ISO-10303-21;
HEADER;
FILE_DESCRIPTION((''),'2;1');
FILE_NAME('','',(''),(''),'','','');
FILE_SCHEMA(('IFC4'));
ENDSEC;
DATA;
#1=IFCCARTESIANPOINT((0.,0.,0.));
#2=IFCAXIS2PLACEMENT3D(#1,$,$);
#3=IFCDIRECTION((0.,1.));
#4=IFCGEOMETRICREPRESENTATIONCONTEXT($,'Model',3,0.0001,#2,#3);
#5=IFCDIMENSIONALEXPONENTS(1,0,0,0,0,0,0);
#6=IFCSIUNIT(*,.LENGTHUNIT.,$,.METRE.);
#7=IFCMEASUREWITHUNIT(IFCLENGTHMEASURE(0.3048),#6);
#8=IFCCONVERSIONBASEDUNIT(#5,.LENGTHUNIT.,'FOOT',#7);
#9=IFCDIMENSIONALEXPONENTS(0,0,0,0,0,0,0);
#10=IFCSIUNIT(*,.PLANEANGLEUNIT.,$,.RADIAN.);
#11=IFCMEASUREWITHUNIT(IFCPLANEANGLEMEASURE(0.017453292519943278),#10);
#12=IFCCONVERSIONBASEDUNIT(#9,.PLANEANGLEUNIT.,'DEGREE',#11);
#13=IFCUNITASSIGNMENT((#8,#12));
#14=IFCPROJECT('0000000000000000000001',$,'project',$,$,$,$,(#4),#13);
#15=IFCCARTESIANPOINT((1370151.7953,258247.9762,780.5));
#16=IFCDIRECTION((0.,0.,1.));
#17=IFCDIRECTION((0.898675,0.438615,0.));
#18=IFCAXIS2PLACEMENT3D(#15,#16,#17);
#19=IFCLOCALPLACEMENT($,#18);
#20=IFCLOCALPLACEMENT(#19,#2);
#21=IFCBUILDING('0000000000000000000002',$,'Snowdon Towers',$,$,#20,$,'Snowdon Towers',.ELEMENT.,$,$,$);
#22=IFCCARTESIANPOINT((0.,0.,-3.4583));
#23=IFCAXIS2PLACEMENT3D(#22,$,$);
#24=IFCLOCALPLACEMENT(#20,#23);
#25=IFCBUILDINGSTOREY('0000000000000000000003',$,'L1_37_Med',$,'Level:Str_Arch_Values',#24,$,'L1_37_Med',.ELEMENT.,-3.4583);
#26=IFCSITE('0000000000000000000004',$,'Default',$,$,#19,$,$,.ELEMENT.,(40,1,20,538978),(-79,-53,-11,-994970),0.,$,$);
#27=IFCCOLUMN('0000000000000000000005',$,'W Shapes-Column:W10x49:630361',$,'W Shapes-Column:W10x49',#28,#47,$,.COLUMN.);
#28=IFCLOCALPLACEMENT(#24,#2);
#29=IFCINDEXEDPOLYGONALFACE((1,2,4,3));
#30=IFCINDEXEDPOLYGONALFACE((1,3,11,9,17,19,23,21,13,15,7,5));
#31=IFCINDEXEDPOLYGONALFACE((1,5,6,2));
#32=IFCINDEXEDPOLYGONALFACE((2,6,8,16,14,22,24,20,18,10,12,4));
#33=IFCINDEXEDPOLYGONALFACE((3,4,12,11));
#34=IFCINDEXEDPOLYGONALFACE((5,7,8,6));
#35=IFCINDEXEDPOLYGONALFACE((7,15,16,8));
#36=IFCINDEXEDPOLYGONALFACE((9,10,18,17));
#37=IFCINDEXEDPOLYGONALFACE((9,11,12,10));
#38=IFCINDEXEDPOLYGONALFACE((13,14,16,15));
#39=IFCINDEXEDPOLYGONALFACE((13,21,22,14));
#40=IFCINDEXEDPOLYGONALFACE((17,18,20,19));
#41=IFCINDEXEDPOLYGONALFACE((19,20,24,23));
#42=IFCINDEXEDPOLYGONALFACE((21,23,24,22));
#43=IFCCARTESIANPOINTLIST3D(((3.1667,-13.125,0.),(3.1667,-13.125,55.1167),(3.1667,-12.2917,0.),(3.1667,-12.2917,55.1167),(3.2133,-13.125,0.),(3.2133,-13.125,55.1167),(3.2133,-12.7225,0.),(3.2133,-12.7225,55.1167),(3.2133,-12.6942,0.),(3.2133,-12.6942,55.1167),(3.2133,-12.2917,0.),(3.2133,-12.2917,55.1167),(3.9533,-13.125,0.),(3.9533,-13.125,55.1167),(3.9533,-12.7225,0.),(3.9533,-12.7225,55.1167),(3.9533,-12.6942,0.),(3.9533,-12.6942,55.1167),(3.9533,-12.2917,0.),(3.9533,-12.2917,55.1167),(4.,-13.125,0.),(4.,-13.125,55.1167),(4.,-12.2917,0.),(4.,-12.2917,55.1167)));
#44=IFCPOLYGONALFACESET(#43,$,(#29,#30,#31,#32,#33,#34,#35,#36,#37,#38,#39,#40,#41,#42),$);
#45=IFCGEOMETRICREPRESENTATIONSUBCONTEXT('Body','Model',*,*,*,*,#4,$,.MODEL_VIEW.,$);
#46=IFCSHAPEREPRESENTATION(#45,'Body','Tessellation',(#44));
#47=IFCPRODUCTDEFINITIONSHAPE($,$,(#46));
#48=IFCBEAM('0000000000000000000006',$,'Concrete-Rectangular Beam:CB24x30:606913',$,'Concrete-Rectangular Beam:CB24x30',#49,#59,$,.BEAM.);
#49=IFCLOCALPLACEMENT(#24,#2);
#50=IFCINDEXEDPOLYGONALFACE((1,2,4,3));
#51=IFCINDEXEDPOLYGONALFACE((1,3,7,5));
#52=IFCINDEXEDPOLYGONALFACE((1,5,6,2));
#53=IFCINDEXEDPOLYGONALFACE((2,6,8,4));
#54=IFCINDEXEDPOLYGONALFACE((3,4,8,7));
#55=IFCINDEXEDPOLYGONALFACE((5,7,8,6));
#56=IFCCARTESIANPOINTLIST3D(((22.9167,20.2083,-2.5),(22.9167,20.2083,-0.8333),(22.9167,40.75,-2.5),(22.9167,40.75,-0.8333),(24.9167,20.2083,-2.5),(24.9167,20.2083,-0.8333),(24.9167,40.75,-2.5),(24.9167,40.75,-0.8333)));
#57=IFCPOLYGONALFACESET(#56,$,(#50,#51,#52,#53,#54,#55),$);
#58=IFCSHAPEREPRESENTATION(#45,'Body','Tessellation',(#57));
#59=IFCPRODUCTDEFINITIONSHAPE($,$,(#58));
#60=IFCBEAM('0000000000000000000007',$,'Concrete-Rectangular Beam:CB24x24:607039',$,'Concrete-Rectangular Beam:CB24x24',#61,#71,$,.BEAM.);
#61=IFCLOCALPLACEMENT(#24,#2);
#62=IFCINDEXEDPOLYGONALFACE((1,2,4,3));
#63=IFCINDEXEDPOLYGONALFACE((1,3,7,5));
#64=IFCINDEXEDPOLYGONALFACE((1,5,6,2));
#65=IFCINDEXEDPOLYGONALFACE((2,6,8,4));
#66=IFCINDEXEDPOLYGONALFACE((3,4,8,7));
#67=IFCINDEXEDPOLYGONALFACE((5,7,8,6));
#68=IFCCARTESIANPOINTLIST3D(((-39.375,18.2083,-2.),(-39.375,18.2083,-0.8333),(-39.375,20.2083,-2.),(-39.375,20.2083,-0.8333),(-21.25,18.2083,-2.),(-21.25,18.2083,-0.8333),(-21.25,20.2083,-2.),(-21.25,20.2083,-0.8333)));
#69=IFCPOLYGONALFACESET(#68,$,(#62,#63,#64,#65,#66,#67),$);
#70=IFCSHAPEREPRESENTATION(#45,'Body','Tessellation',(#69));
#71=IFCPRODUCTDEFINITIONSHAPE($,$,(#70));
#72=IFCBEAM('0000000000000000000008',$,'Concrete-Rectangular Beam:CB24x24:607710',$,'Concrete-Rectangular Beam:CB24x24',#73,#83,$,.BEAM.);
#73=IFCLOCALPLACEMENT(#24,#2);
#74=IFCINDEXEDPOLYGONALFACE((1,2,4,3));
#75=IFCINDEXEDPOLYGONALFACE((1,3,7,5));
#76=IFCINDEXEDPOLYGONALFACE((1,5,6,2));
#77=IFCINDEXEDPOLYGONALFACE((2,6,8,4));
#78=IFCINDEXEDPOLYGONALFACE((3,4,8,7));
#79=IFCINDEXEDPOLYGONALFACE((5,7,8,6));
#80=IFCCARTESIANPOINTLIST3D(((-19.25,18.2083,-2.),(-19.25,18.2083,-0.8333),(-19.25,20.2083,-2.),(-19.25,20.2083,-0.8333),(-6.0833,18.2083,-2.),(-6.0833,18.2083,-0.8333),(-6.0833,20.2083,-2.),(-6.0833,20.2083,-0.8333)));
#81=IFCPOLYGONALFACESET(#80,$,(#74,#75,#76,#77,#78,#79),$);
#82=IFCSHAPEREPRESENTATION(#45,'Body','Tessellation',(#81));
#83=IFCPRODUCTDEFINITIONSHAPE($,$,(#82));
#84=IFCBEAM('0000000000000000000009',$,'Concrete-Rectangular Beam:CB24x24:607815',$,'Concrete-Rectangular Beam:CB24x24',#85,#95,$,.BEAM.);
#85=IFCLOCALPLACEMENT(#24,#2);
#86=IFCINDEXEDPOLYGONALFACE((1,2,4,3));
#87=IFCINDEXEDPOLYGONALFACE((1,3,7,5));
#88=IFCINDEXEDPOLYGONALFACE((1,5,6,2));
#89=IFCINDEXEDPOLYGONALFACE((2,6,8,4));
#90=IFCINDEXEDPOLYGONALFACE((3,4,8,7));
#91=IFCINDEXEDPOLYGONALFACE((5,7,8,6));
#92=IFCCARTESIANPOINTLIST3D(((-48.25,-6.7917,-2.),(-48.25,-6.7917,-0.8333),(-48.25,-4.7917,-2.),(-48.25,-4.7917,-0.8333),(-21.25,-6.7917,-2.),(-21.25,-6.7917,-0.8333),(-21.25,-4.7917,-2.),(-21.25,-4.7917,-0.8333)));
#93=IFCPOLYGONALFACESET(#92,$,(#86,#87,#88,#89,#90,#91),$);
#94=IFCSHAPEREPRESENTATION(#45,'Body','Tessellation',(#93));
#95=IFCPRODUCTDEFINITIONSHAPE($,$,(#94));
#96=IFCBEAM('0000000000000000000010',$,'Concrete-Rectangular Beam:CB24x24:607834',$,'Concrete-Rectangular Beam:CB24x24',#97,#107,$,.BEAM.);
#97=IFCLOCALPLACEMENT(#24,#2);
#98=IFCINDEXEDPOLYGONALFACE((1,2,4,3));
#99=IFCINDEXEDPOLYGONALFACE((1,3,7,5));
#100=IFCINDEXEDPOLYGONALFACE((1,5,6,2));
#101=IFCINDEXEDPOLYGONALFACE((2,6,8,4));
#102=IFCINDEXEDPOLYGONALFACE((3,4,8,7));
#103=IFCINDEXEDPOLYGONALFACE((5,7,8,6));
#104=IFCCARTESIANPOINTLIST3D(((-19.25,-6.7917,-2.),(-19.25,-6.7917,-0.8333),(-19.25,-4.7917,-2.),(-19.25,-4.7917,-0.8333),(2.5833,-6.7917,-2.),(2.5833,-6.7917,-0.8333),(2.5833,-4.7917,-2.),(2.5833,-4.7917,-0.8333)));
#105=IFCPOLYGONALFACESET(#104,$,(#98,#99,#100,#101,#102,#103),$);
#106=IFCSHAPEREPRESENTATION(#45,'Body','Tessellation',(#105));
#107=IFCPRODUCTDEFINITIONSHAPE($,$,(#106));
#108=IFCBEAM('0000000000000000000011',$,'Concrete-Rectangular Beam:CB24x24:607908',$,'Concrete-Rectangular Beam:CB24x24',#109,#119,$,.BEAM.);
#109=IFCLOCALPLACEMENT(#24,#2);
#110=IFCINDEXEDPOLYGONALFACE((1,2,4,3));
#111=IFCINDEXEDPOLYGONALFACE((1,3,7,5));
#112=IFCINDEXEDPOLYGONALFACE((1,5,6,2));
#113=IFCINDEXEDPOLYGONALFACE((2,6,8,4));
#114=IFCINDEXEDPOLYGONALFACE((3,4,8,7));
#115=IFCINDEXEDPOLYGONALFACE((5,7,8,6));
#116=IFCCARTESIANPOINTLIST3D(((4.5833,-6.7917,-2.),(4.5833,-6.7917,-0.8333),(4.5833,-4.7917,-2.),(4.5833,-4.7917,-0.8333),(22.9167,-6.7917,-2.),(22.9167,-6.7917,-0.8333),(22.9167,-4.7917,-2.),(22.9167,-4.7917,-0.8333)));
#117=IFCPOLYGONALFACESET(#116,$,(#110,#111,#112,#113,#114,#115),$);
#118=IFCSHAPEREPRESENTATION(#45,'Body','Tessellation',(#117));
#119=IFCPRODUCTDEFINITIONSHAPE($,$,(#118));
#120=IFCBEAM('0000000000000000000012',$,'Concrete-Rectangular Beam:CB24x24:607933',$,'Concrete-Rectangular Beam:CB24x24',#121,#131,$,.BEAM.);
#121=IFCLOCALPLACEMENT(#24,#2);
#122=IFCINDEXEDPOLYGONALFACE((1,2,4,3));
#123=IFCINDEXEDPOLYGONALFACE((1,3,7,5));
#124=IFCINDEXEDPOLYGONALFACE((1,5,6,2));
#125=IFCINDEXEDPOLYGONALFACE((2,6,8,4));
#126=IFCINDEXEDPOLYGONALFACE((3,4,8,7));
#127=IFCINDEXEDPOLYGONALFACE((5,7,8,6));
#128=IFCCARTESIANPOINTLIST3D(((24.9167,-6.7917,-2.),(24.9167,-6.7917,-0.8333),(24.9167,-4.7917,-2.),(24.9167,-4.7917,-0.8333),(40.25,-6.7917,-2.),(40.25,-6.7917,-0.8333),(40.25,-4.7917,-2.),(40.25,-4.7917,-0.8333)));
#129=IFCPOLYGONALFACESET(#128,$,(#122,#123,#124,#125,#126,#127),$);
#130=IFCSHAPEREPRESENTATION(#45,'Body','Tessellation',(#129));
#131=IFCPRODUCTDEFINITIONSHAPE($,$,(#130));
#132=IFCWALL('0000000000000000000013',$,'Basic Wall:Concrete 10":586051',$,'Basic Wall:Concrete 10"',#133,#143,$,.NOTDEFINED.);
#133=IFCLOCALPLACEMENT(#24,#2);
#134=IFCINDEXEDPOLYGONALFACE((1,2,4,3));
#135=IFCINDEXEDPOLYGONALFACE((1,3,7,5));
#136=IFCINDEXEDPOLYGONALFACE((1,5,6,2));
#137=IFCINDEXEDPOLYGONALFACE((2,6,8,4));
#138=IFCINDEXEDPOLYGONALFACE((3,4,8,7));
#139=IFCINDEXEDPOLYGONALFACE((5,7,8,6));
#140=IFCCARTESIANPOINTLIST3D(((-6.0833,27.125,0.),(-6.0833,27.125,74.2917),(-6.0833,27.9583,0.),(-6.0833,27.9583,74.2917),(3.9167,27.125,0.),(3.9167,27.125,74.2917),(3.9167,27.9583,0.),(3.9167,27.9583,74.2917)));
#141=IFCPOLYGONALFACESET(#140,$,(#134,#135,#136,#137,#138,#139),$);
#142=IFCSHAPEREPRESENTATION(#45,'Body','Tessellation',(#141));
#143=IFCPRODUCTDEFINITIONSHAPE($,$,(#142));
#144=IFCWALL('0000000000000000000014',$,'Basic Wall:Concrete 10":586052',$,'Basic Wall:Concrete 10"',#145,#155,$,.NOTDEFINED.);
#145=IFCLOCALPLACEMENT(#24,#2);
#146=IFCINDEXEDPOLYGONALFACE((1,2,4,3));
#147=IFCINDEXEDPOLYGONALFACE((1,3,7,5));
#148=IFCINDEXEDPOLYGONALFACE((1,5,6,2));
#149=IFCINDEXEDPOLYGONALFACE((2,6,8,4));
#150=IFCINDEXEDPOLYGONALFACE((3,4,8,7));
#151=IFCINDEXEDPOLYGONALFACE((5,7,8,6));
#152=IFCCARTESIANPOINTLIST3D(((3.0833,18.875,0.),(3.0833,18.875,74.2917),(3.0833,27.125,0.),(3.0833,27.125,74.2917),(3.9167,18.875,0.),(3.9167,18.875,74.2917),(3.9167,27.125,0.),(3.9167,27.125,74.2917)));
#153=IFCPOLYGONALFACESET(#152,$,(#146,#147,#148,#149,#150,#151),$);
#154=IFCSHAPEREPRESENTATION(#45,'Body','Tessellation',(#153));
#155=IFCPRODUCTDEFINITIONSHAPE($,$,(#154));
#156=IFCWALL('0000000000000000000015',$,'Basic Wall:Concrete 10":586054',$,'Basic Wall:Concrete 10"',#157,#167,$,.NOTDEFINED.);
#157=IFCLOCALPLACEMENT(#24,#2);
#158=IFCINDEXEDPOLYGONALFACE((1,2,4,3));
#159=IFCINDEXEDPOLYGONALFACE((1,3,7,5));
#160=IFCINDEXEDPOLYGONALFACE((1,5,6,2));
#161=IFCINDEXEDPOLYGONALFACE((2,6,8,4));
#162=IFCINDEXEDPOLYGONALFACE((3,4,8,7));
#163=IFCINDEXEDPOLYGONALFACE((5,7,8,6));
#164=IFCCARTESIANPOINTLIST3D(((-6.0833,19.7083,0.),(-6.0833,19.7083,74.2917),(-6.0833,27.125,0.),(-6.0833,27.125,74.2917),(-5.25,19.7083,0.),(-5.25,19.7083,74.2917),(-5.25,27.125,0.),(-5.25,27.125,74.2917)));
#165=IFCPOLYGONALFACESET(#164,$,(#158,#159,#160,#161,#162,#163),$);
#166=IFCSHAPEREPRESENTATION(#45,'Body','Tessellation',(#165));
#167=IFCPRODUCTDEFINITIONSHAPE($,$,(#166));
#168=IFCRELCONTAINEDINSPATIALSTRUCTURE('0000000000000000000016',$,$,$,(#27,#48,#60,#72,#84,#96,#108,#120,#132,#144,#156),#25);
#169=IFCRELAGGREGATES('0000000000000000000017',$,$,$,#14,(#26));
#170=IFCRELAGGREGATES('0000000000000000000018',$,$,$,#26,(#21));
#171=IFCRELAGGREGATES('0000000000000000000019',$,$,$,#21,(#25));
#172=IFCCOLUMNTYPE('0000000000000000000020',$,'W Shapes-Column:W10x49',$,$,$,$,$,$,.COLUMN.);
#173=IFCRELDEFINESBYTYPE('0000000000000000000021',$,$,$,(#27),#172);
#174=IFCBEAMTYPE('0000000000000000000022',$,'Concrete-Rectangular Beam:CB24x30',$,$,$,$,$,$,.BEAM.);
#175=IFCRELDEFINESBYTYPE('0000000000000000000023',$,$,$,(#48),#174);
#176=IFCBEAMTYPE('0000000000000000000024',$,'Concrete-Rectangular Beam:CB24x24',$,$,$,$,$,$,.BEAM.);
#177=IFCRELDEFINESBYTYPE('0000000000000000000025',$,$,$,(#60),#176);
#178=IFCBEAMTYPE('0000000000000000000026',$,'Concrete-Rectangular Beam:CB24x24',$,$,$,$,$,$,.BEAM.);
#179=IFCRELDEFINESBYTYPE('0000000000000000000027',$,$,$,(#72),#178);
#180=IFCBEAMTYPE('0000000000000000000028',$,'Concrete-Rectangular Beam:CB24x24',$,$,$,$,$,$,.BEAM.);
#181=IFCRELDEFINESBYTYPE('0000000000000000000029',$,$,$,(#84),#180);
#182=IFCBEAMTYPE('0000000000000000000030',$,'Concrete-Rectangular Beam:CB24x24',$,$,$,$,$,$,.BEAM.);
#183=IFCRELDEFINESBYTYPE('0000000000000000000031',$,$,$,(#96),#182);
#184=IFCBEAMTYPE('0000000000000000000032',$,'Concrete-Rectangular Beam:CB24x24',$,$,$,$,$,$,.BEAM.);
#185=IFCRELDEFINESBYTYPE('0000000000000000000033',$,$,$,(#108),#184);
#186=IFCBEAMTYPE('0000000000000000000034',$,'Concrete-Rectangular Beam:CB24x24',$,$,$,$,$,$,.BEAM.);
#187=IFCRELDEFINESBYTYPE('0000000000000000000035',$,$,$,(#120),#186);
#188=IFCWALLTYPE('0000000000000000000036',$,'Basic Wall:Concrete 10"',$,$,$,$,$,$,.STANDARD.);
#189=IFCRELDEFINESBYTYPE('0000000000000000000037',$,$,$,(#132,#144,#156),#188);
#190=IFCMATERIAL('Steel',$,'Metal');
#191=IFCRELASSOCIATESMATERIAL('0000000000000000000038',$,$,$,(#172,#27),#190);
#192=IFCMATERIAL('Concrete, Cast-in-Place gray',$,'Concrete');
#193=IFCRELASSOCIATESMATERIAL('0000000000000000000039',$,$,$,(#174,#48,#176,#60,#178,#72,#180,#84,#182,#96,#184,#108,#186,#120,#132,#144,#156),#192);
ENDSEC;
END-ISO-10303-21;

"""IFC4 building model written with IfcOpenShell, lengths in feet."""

from ifc_helpers import new_model, entity, si_unit, converted_unit, direction, frame, origin, place, context, subcontext, project, spatial, indexed_curve, outline, extrude, source, transform, mapped, material, type_object, type_shapes, element, save


model = new_model("IFC4")

# Units and contexts
model_context = context("Model", 3, precision=0.0001, world=origin(), true_north=direction((0.0, 1.0)))
body_context = subcontext(model_context, "Body", "Model", "MODEL_VIEW")
ifc_project = project(units=[converted_unit("LENGTHUNIT", "FOOT", entity("IfcLengthMeasure", 0.3048), si_unit("LENGTHUNIT", "METRE"), dimensions=[1, 0, 0, 0, 0, 0, 0]), converted_unit("PLANEANGLEUNIT", "DEGREE", entity("IfcPlaneAngleMeasure", 0.017453292519943278), si_unit("PLANEANGLEUNIT", "RADIAN"), dimensions=[0, 0, 0, 0, 0, 0, 0])], contexts=[model_context])

# Site, building, storey
site_placement = place(None, frame((1370151.7953, 258247.9762, 780.5), z_axis=(0.0, 0.0, 1.0), x_axis=(0.898675, 0.438615, 0.0)))
site = spatial("IfcSite", under=ifc_project, at=site_placement, Name="Default", CompositionType="ELEMENT", RefLatitude=(40, 1, 20, 538978), RefLongitude=(-79, -53, -11, -994970), RefElevation=0.0)
building_placement = place(site_placement, origin())
building = spatial("IfcBuilding", under=site, at=building_placement, Name="Snowdon Towers", LongName="Snowdon Towers", CompositionType="ELEMENT")
storey_placement = place(building_placement, frame((0.0, 0.0, -3.4583)))
storey = spatial("IfcBuildingStorey", under=building, at=storey_placement, Name="L1_37_Med", ObjectType="Level:Str_Arch_Values", LongName="L1_37_Med", CompositionType="ELEMENT", Elevation=-3.4583)

# Column
ifc_material_1 = material(Name="Steel", Category="Metal")
column_type_1 = type_object("IfcColumnType", Name="W Shapes-Column:W10x49", PredefinedType="COLUMN", material=ifc_material_1)
shared_shape_1 = source(origin(), body_context, "Body", "SweptSolid", [
    extrude(outline(indexed_curve([(-0.4167, -0.4167), (0.4167, -0.4167), (0.4167, -0.37), (0.0142, -0.37), (0.0142, 0.37), (0.4167, 0.37), (0.4167, 0.4167), (-0.4167, 0.4167), (-0.4167, 0.37), (-0.0142, 0.37), (-0.0142, -0.37), (-0.4167, -0.37), (-0.4167, -0.4167)], self_intersect=False)), frame((3.5833, -12.7083, -3.4583), z_axis=(0.0, 0.0, 1.0), x_axis=(0.0, -1.0, 0.0)), (0.0, 0.0, 1.0), 55.1167),
])
type_shapes(column_type_1, [shared_shape_1])
column_1_placement = place(storey_placement, frame((0.0, 0.0, 3.4583)))
element("IfcColumn", 1, at=column_1_placement, inside=storey, type_object=column_type_1, material=ifc_material_1, Name="W Shapes-Column:W10x49:630361", ObjectType="W Shapes-Column:W10x49", PredefinedType="COLUMN", context=body_context, shape_type="MappedRepresentation", body=[
    mapped(shared_shape_1, transform((0.0, 0.0, 0.0), scale=1.0)),
])

# Beams
ifc_material_2 = material(Name="Concrete, Cast-in-Place gray", Category="Concrete")
beam_type_1 = type_object("IfcBeamType", Name="Concrete-Rectangular Beam:CB24x30", PredefinedType="BEAM", material=ifc_material_2)
shared_shape_2 = source(origin(), body_context, "Body", "SweptSolid", [
    extrude(outline(indexed_curve([(-1.0, -0.8333), (1.0, -0.8333), (1.0, 0.8333), (-1.0, 0.8333), (-1.0, -0.8333)], self_intersect=False)), frame((23.9167, 20.2083, -5.125), z_axis=(0.0, 1.0, 0.0), x_axis=(-1.0, 0.0, 0.0)), (0.0, 0.0, 1.0), 20.5417),
])
type_shapes(beam_type_1, [shared_shape_2])
beam_1_placement = place(storey_placement, frame((0.0, 0.0, 3.4583)))
element("IfcBeam", 2, at=beam_1_placement, inside=storey, type_object=beam_type_1, material=ifc_material_2, Name="Concrete-Rectangular Beam:CB24x30:606913", ObjectType="Concrete-Rectangular Beam:CB24x30", PredefinedType="BEAM", context=body_context, shape_type="MappedRepresentation", body=[
    mapped(shared_shape_2, transform((0.0, 0.0, 0.0), scale=1.0)),
])
beam_type_2 = type_object("IfcBeamType", Name="Concrete-Rectangular Beam:CB24x24", PredefinedType="BEAM", material=ifc_material_2)
shared_shape_3 = source(origin(), body_context, "Body", "SweptSolid", [
    extrude(outline(indexed_curve([(-0.5833, -1.0), (0.5833, -1.0), (0.5833, 1.0), (-0.5833, 1.0), (-0.5833, -1.0)], self_intersect=False)), frame((-39.375, 19.2083, -4.875), z_axis=(1.0, 0.0, 0.0), x_axis=(0.0, 0.0, -1.0)), (0.0, 0.0, 1.0), 18.125),
])
type_shapes(beam_type_2, [shared_shape_3])
beam_2_placement = place(storey_placement, frame((0.0, 0.0, 3.4583)))
element("IfcBeam", 3, at=beam_2_placement, inside=storey, type_object=beam_type_2, material=ifc_material_2, Name="Concrete-Rectangular Beam:CB24x24:607039", ObjectType="Concrete-Rectangular Beam:CB24x24", PredefinedType="BEAM", context=body_context, shape_type="MappedRepresentation", body=[
    mapped(shared_shape_3, transform((0.0, 0.0, 0.0), scale=1.0)),
])
beam_type_3 = type_object("IfcBeamType", Name="Concrete-Rectangular Beam:CB24x24", PredefinedType="BEAM", material=ifc_material_2)
shared_shape_4 = source(origin(), body_context, "Body", "SweptSolid", [
    extrude(outline(indexed_curve([(-0.5833, -1.0), (0.5833, -1.0), (0.5833, 1.0), (-0.5833, 1.0), (-0.5833, -1.0)], self_intersect=False)), frame((-19.25, 19.2083, -4.875), z_axis=(1.0, 0.0, 0.0), x_axis=(0.0, 0.0, -1.0)), (0.0, 0.0, 1.0), 13.1667),
])
type_shapes(beam_type_3, [shared_shape_4])
beam_3_placement = place(storey_placement, frame((0.0, 0.0, 3.4583)))
element("IfcBeam", 4, at=beam_3_placement, inside=storey, type_object=beam_type_3, material=ifc_material_2, Name="Concrete-Rectangular Beam:CB24x24:607710", ObjectType="Concrete-Rectangular Beam:CB24x24", PredefinedType="BEAM", context=body_context, shape_type="MappedRepresentation", body=[
    mapped(shared_shape_4, transform((0.0, 0.0, 0.0), scale=1.0)),
])
beam_type_4 = type_object("IfcBeamType", Name="Concrete-Rectangular Beam:CB24x24", PredefinedType="BEAM", material=ifc_material_2)
shared_shape_5 = source(origin(), body_context, "Body", "SweptSolid", [
    extrude(outline(indexed_curve([(-0.5833, -1.0), (0.5833, -1.0), (0.5833, 1.0), (-0.5833, 1.0), (-0.5833, -1.0)], self_intersect=False)), frame((-48.25, -5.7917, -4.875), z_axis=(1.0, 0.0, 0.0), x_axis=(0.0, 0.0, -1.0)), (0.0, 0.0, 1.0), 27.0),
])
type_shapes(beam_type_4, [shared_shape_5])
beam_4_placement = place(storey_placement, frame((0.0, 0.0, 3.4583)))
element("IfcBeam", 5, at=beam_4_placement, inside=storey, type_object=beam_type_4, material=ifc_material_2, Name="Concrete-Rectangular Beam:CB24x24:607815", ObjectType="Concrete-Rectangular Beam:CB24x24", PredefinedType="BEAM", context=body_context, shape_type="MappedRepresentation", body=[
    mapped(shared_shape_5, transform((0.0, 0.0, 0.0), scale=1.0)),
])
beam_type_5 = type_object("IfcBeamType", Name="Concrete-Rectangular Beam:CB24x24", PredefinedType="BEAM", material=ifc_material_2)
shared_shape_6 = source(origin(), body_context, "Body", "SweptSolid", [
    extrude(outline(indexed_curve([(-0.5833, -1.0), (0.5833, -1.0), (0.5833, 1.0), (-0.5833, 1.0), (-0.5833, -1.0)], self_intersect=False)), frame((-19.25, -5.7917, -4.875), z_axis=(1.0, 0.0, 0.0), x_axis=(0.0, 0.0, -1.0)), (0.0, 0.0, 1.0), 21.8333),
])
type_shapes(beam_type_5, [shared_shape_6])
beam_5_placement = place(storey_placement, frame((0.0, 0.0, 3.4583)))
element("IfcBeam", 6, at=beam_5_placement, inside=storey, type_object=beam_type_5, material=ifc_material_2, Name="Concrete-Rectangular Beam:CB24x24:607834", ObjectType="Concrete-Rectangular Beam:CB24x24", PredefinedType="BEAM", context=body_context, shape_type="MappedRepresentation", body=[
    mapped(shared_shape_6, transform((0.0, 0.0, 0.0), scale=1.0)),
])
beam_type_6 = type_object("IfcBeamType", Name="Concrete-Rectangular Beam:CB24x24", PredefinedType="BEAM", material=ifc_material_2)
shared_shape_7 = source(origin(), body_context, "Body", "SweptSolid", [
    extrude(outline(indexed_curve([(-0.5833, -1.0), (0.5833, -1.0), (0.5833, 1.0), (-0.5833, 1.0), (-0.5833, -1.0)], self_intersect=False)), frame((4.5833, -5.7917, -4.875), z_axis=(1.0, 0.0, 0.0), x_axis=(0.0, 0.0, -1.0)), (0.0, 0.0, 1.0), 18.3333),
])
type_shapes(beam_type_6, [shared_shape_7])
beam_6_placement = place(storey_placement, frame((0.0, 0.0, 3.4583)))
element("IfcBeam", 7, at=beam_6_placement, inside=storey, type_object=beam_type_6, material=ifc_material_2, Name="Concrete-Rectangular Beam:CB24x24:607908", ObjectType="Concrete-Rectangular Beam:CB24x24", PredefinedType="BEAM", context=body_context, shape_type="MappedRepresentation", body=[
    mapped(shared_shape_7, transform((0.0, 0.0, 0.0), scale=1.0)),
])
beam_type_7 = type_object("IfcBeamType", Name="Concrete-Rectangular Beam:CB24x24", PredefinedType="BEAM", material=ifc_material_2)
shared_shape_8 = source(origin(), body_context, "Body", "SweptSolid", [
    extrude(outline(indexed_curve([(-0.5833, -1.0), (0.5833, -1.0), (0.5833, 1.0), (-0.5833, 1.0), (-0.5833, -1.0)], self_intersect=False)), frame((24.9167, -5.7917, -4.875), z_axis=(1.0, 0.0, 0.0), x_axis=(0.0, 0.0, -1.0)), (0.0, 0.0, 1.0), 15.3333),
])
type_shapes(beam_type_7, [shared_shape_8])
beam_7_placement = place(storey_placement, frame((0.0, 0.0, 3.4583)))
element("IfcBeam", 8, at=beam_7_placement, inside=storey, type_object=beam_type_7, material=ifc_material_2, Name="Concrete-Rectangular Beam:CB24x24:607933", ObjectType="Concrete-Rectangular Beam:CB24x24", PredefinedType="BEAM", context=body_context, shape_type="MappedRepresentation", body=[
    mapped(shared_shape_8, transform((0.0, 0.0, 0.0), scale=1.0)),
])

# Walls
wall_type = type_object("IfcWallType", Name="Basic Wall:Concrete 10\"", PredefinedType="STANDARD")
wall_1_placement = place(storey_placement, frame((-6.0833, 27.5417, 0.0)))
element("IfcWall", 9, at=wall_1_placement, inside=storey, type_object=wall_type, material=ifc_material_2, Name="Basic Wall:Concrete 10\":586051", ObjectType="Basic Wall:Concrete 10\"", PredefinedType="NOTDEFINED", context=body_context, shape_type="SweptSolid", body=[
    extrude(outline(indexed_curve([(10.0, 0.4167), (0.0, 0.4167), (0.0, -0.4167), (10.0, -0.4167), (10.0, 0.4167)], self_intersect=False)), origin(), (0.0, 0.0, 1.0), 74.2917),
])
wall_2_placement = place(storey_placement, frame((3.5, 27.125, 0.0), z_axis=(0.0, 0.0, 1.0), x_axis=(0.0, -1.0, 0.0)))
element("IfcWall", 10, at=wall_2_placement, inside=storey, type_object=wall_type, material=ifc_material_2, Name="Basic Wall:Concrete 10\":586052", ObjectType="Basic Wall:Concrete 10\"", PredefinedType="NOTDEFINED", context=body_context, shape_type="SweptSolid", body=[
    extrude(outline(indexed_curve([(8.25, 0.4167), (0.0, 0.4167), (0.0, -0.4167), (8.25, -0.4167), (8.25, 0.4167)], self_intersect=False)), origin(), (0.0, 0.0, 1.0), 74.2917),
])
wall_3_placement = place(storey_placement, frame((-5.6667, 19.7083, 0.0), z_axis=(0.0, 0.0, 1.0), x_axis=(0.0, 1.0, 0.0)))
element("IfcWall", 11, at=wall_3_placement, inside=storey, type_object=wall_type, material=ifc_material_2, Name="Basic Wall:Concrete 10\":586054", ObjectType="Basic Wall:Concrete 10\"", PredefinedType="NOTDEFINED", context=body_context, shape_type="SweptSolid", body=[
    extrude(outline(indexed_curve([(7.4167, 0.4167), (0.0, 0.4167), (0.0, -0.4167), (7.4167, -0.4167), (7.4167, 0.4167)], self_intersect=False)), origin(), (0.0, 0.0, 1.0), 74.2917),
])

save(model, "model.ifc")
